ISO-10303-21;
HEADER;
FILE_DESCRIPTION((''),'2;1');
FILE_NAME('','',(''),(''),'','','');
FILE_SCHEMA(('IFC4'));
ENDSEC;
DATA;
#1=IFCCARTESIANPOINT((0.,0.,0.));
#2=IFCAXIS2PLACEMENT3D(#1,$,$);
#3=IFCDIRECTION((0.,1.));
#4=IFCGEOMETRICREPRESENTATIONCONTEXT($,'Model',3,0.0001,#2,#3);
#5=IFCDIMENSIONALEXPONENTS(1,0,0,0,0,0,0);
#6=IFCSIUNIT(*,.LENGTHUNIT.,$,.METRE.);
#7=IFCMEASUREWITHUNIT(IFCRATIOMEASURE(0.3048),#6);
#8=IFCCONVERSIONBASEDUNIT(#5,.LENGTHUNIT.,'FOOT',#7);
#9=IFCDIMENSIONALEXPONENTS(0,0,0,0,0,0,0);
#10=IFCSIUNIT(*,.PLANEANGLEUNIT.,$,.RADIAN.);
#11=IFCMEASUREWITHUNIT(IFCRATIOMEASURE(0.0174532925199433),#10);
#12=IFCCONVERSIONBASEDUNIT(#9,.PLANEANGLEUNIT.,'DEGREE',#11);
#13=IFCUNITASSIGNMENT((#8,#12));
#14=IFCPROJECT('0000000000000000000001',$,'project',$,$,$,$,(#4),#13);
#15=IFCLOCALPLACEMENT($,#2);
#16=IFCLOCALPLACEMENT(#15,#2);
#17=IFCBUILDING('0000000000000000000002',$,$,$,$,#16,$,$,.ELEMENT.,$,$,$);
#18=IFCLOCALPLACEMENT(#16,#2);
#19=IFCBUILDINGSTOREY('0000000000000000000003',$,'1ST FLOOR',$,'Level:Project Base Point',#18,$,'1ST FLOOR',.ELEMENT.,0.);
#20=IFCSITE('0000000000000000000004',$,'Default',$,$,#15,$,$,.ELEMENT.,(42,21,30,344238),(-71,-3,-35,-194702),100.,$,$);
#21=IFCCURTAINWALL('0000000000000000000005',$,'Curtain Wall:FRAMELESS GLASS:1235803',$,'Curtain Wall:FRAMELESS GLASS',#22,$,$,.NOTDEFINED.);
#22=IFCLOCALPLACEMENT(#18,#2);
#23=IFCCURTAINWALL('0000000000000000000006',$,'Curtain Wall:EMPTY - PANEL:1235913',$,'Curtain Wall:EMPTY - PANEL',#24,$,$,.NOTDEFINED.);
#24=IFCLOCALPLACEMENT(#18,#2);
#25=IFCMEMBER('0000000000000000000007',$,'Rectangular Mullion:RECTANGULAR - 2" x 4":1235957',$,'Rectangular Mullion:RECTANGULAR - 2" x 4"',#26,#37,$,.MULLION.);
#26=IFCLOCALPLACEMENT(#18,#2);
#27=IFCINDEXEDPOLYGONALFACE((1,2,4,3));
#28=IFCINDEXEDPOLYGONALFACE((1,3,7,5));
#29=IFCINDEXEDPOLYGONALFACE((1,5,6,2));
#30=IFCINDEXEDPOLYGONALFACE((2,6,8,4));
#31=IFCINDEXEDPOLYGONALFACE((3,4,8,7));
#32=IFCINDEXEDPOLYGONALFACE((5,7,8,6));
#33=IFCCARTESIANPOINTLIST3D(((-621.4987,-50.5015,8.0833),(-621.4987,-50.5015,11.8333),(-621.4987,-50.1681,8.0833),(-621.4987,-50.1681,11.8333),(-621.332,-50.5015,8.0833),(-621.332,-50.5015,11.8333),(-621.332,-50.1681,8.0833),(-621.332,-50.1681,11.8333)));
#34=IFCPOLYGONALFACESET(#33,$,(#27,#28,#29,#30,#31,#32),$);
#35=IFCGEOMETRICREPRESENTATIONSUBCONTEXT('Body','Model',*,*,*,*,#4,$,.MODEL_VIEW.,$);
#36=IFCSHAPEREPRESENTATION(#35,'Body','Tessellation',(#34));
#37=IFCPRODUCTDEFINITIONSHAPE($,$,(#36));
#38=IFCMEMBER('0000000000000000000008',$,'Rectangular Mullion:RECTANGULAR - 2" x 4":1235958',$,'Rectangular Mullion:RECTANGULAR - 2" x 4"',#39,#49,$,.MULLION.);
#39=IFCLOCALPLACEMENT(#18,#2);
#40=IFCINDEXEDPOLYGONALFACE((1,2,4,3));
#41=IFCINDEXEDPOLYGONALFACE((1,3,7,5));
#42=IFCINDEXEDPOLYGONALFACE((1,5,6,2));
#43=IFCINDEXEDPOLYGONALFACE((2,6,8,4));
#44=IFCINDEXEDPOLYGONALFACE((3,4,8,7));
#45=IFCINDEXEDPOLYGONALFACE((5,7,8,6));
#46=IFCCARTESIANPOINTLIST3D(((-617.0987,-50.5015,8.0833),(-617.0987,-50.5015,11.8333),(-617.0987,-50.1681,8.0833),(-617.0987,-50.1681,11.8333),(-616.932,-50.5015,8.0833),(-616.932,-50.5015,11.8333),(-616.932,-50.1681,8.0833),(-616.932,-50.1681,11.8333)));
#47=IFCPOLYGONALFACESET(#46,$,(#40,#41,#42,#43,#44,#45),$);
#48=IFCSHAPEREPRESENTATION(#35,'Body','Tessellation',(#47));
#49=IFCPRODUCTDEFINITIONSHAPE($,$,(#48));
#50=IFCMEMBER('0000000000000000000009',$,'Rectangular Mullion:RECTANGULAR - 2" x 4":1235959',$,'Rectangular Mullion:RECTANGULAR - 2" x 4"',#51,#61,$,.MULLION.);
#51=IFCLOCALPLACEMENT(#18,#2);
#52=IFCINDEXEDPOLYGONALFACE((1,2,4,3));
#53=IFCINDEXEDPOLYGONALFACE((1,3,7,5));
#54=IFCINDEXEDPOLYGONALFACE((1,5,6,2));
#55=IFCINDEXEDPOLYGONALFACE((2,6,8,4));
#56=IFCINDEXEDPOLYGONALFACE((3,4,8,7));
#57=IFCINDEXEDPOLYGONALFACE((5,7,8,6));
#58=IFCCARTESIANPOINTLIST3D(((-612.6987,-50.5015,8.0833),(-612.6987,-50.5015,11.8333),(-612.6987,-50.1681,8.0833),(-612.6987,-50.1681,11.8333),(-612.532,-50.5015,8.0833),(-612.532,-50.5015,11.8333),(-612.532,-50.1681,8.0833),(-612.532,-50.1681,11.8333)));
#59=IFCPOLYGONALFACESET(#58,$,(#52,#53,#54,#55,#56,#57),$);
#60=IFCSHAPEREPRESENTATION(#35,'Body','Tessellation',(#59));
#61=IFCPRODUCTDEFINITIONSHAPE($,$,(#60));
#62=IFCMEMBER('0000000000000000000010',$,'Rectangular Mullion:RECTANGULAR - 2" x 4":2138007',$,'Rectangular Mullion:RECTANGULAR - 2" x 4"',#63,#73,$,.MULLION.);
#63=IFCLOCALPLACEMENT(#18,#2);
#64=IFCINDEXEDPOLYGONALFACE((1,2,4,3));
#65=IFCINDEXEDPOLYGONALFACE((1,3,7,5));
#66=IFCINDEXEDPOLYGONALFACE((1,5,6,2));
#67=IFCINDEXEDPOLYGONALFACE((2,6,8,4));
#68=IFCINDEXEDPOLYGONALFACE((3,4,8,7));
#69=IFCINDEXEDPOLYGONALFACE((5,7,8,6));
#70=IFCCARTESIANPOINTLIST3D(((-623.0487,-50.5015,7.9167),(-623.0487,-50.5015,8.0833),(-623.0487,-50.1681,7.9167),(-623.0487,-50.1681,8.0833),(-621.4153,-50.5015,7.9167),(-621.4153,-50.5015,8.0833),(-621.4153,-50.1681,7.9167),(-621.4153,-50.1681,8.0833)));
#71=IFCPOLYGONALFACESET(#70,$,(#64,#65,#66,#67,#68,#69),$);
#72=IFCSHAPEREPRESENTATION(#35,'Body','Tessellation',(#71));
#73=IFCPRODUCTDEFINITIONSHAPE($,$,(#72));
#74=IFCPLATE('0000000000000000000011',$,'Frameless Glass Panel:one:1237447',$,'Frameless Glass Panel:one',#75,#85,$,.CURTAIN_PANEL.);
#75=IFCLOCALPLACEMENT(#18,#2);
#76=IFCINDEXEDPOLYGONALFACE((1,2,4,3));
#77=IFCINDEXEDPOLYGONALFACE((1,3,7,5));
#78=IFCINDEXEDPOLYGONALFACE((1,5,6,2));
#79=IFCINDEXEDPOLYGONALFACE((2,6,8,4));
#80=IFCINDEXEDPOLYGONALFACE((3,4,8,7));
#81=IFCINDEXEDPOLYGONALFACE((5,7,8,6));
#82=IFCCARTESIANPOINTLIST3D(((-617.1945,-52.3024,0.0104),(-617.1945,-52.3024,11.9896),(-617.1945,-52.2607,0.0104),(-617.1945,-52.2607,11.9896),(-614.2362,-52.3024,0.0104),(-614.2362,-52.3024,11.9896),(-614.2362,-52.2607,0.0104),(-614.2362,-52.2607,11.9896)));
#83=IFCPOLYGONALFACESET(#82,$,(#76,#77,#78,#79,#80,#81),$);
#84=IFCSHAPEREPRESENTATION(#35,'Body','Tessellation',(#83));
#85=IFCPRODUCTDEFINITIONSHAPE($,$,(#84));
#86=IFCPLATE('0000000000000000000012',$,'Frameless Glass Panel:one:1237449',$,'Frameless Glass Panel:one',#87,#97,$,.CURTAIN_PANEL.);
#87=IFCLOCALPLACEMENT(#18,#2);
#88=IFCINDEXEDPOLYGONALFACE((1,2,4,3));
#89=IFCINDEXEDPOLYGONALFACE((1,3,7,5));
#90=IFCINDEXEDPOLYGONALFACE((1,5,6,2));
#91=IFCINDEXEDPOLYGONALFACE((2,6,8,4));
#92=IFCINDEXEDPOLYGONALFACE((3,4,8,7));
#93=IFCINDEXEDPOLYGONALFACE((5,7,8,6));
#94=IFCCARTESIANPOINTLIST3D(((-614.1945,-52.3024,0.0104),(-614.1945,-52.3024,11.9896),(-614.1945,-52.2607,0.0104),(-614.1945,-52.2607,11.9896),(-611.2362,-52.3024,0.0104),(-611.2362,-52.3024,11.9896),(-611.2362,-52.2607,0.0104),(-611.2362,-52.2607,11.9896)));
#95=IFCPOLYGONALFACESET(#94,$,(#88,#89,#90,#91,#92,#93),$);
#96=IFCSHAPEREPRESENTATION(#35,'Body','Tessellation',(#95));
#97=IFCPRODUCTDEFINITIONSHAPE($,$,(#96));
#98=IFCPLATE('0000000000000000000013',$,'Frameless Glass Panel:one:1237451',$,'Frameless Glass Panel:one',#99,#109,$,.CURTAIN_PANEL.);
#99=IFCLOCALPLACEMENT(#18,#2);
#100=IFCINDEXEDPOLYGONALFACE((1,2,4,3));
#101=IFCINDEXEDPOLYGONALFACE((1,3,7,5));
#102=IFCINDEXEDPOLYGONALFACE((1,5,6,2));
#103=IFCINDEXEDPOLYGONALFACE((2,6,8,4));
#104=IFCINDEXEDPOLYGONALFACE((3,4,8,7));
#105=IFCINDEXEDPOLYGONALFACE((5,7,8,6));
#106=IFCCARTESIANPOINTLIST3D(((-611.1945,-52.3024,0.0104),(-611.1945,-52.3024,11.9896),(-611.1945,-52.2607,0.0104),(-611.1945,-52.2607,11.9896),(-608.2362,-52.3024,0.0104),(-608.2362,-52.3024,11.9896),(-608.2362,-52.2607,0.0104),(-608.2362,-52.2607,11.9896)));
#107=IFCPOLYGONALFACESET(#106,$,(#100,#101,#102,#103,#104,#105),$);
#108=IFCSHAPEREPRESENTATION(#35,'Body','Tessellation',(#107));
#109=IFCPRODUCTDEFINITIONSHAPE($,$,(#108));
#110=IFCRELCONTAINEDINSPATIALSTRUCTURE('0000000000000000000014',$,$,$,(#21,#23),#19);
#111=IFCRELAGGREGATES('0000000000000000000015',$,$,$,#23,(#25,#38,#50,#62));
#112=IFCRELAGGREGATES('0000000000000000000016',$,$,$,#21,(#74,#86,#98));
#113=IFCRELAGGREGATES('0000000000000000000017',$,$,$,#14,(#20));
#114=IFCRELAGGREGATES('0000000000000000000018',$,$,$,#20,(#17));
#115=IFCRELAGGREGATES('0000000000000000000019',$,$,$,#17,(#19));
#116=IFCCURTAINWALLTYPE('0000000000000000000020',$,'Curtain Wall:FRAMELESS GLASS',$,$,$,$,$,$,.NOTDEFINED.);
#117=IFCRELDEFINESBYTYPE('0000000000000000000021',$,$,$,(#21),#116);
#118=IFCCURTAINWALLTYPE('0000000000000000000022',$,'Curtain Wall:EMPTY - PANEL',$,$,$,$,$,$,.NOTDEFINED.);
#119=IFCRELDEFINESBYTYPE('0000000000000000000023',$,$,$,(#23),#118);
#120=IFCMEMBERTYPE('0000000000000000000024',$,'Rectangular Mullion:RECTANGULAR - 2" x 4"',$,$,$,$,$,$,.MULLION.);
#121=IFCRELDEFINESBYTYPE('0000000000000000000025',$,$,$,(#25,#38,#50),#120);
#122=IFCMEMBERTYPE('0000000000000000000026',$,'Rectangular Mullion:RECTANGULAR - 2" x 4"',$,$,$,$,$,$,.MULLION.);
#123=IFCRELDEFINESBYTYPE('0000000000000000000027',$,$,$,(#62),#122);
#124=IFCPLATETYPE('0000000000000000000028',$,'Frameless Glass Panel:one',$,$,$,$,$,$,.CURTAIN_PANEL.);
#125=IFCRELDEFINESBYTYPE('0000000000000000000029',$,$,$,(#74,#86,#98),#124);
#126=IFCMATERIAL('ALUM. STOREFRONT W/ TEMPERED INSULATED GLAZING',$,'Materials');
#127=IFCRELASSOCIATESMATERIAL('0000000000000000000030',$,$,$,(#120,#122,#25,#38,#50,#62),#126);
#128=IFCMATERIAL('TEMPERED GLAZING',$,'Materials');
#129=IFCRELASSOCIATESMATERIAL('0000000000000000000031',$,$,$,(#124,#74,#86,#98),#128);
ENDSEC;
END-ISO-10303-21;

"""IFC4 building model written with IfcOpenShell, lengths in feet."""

from ifc_helpers import new_model, entity, si_unit, converted_unit, direction, frame, origin, origin_2d_with_axis, place, context, subcontext, project, spatial, rectangle, extrude, source, transform, mapped, material, material_profile, profile_set, profile_usage, type_object, type_shapes, element, aggregate, save


model = new_model("IFC4")

# Units and contexts
model_context = context("Model", 3, precision=0.0001, world=origin(), true_north=direction((0.0, 1.0)))
body_context = subcontext(model_context, "Body", "Model", "MODEL_VIEW")
ifc_project = project(units=[converted_unit("LENGTHUNIT", "FOOT", entity("IfcRatioMeasure", 0.3048), si_unit("LENGTHUNIT", "METRE"), dimensions=[1, 0, 0, 0, 0, 0, 0]), converted_unit("PLANEANGLEUNIT", "DEGREE", entity("IfcRatioMeasure", 0.0174532925199433), si_unit("PLANEANGLEUNIT", "RADIAN"), dimensions=[0, 0, 0, 0, 0, 0, 0])], contexts=[model_context])

# Site, building, storey
site_placement = place(None, origin())
site = spatial("IfcSite", under=ifc_project, at=site_placement, Name="Default", CompositionType="ELEMENT", RefLatitude=(42, 21, 30, 344238), RefLongitude=(-71, -3, -35, -194702), RefElevation=100.0)
building_placement = place(site_placement, origin())
building = spatial("IfcBuilding", under=site, at=building_placement, CompositionType="ELEMENT")
storey_placement = place(building_placement, origin())
storey = spatial("IfcBuildingStorey", under=building, at=storey_placement, Name="1ST FLOOR", ObjectType="Level:Project Base Point", LongName="1ST FLOOR", CompositionType="ELEMENT", Elevation=0.0)

# Curtain walls, members
curtain_wall_type_1 = type_object("IfcCurtainWallType", Name="Curtain Wall:FRAMELESS GLASS", PredefinedType="NOTDEFINED")
curtain_wall_1_placement = place(storey_placement, origin())
curtain_wall_1 = element("IfcCurtainWall", 1, at=curtain_wall_1_placement, inside=storey, type_object=curtain_wall_type_1, Name="Curtain Wall:FRAMELESS GLASS:1235803", ObjectType="Curtain Wall:FRAMELESS GLASS", PredefinedType="NOTDEFINED")
curtain_wall_type_2 = type_object("IfcCurtainWallType", Name="Curtain Wall:EMPTY - PANEL", PredefinedType="NOTDEFINED")
curtain_wall_2_placement = place(storey_placement, origin())
curtain_wall_2 = element("IfcCurtainWall", 2, at=curtain_wall_2_placement, inside=storey, type_object=curtain_wall_type_2, Name="Curtain Wall:EMPTY - PANEL:1235913", ObjectType="Curtain Wall:EMPTY - PANEL", PredefinedType="NOTDEFINED")
ifc_material_1 = material(Name="ALUM. STOREFRONT W/ TEMPERED INSULATED GLAZING", Category="Materials")
ifc_material_profile_1 = material_profile(ifc_material_1, rectangle(XDim=0.3333, YDim=0.1667, at=origin_2d_with_axis()), Name="RECTANGULAR - 2\" x 4\"")
ifc_profile_set_1 = profile_set([ifc_material_profile_1], Name="RECTANGULAR - 2\" x 4\"")
ifc_profile_usage_1 = profile_usage(ifc_profile_set_1)
member_type_1 = type_object("IfcMemberType", Name="Rectangular Mullion:RECTANGULAR - 2\" x 4\"", PredefinedType="MULLION", material=ifc_profile_set_1)
shared_shape_1 = source(origin(), body_context, "Body", "SweptSolid", [
    extrude(rectangle(XDim=0.3333, YDim=0.1667, at=origin_2d_with_axis()), frame((0.0, 0.0, -3.75), z_axis=(0.0, 0.0, 1.0), x_axis=(0.0, -1.0, 0.0)), (0.0, 0.0, 1.0), 3.75),
])
type_shapes(member_type_1, [shared_shape_1])
member_1_placement = place(storey_placement, frame((-621.4153, -50.3348, 8.0833), z_axis=(0.0, 0.0, -1.0), x_axis=(1.0, 0.0, 0.0)))
member_1 = element("IfcMember", 3, at=member_1_placement, type_object=member_type_1, material=ifc_profile_usage_1, Name="Rectangular Mullion:RECTANGULAR - 2\" x 4\":1235957", ObjectType="Rectangular Mullion:RECTANGULAR - 2\" x 4\"", PredefinedType="MULLION", context=body_context, shape_type="MappedRepresentation", body=[
    mapped(shared_shape_1, transform((0.0, 0.0, 0.0), scale=1.0)),
])
ifc_profile_usage_2 = profile_usage(ifc_profile_set_1)
member_2_placement = place(storey_placement, frame((-617.0153, -50.3348, 8.0833), z_axis=(0.0, 0.0, -1.0), x_axis=(1.0, 0.0, 0.0)))
member_2 = element("IfcMember", 4, at=member_2_placement, type_object=member_type_1, material=ifc_profile_usage_2, Name="Rectangular Mullion:RECTANGULAR - 2\" x 4\":1235958", ObjectType="Rectangular Mullion:RECTANGULAR - 2\" x 4\"", PredefinedType="MULLION", context=body_context, shape_type="MappedRepresentation", body=[
    mapped(shared_shape_1, transform((0.0, 0.0, 0.0), scale=1.0)),
])
ifc_profile_usage_3 = profile_usage(ifc_profile_set_1)
member_3_placement = place(storey_placement, frame((-612.6153, -50.3348, 8.0833), z_axis=(0.0, 0.0, -1.0), x_axis=(1.0, 0.0, 0.0)))
member_3 = element("IfcMember", 5, at=member_3_placement, type_object=member_type_1, material=ifc_profile_usage_3, Name="Rectangular Mullion:RECTANGULAR - 2\" x 4\":1235959", ObjectType="Rectangular Mullion:RECTANGULAR - 2\" x 4\"", PredefinedType="MULLION", context=body_context, shape_type="MappedRepresentation", body=[
    mapped(shared_shape_1, transform((0.0, 0.0, 0.0), scale=1.0)),
])
ifc_profile_usage_4 = profile_usage(ifc_profile_set_1)
member_type_2 = type_object("IfcMemberType", Name="Rectangular Mullion:RECTANGULAR - 2\" x 4\"", PredefinedType="MULLION", material=ifc_profile_set_1)
shared_shape_2 = source(origin(), body_context, "Body", "SweptSolid", [
    extrude(rectangle(XDim=0.3333, YDim=0.1667, at=origin_2d_with_axis()), frame((0.0, 0.0, -1.6333), z_axis=(0.0, 0.0, 1.0), x_axis=(0.0, -1.0, 0.0)), (0.0, 0.0, 1.0), 1.6333),
])
type_shapes(member_type_2, [shared_shape_2])
member_4_placement = place(storey_placement, frame((-621.4153, -50.3348, 8.0), z_axis=(1.0, 0.0, 0.0), x_axis=(0.0, 0.0, 1.0)))
member_4 = element("IfcMember", 6, at=member_4_placement, type_object=member_type_2, material=ifc_profile_usage_4, Name="Rectangular Mullion:RECTANGULAR - 2\" x 4\":2138007", ObjectType="Rectangular Mullion:RECTANGULAR - 2\" x 4\"", PredefinedType="MULLION", context=body_context, shape_type="MappedRepresentation", body=[
    mapped(shared_shape_2, transform((0.0, 0.0, 0.0), scale=1.0)),
])
aggregate(curtain_wall_2, [member_1, member_2, member_3, member_4])

# Plates
ifc_material_2 = material(Name="TEMPERED GLAZING", Category="Materials")
plate_type = type_object("IfcPlateType", Name="Frameless Glass Panel:one", PredefinedType="CURTAIN_PANEL", material=ifc_material_2)
shared_shape_3 = source(origin(), body_context, "Body", "SweptSolid", [
    extrude(rectangle(XDim=0.0417, YDim=2.9583, at=origin_2d_with_axis()), frame((0.0, 0.0, 0.0), z_axis=(0.0, 0.0, 1.0), x_axis=(0.0, 1.0, 0.0)), (0.0, 0.0, 1.0), 11.9792),
])
type_shapes(plate_type, [shared_shape_3])
plate_1_placement = place(curtain_wall_1_placement, frame((-615.7153, -52.2815, 0.0104)))
plate_1 = element("IfcPlate", 7, at=plate_1_placement, type_object=plate_type, material=ifc_material_2, Name="Frameless Glass Panel:one:1237447", ObjectType="Frameless Glass Panel:one", PredefinedType="CURTAIN_PANEL", context=body_context, shape_type="MappedRepresentation", body=[
    mapped(shared_shape_3, transform((0.0, 0.0, 0.0), scale=1.0)),
])
plate_2_placement = place(curtain_wall_1_placement, frame((-612.7153, -52.2815, 0.0104)))
plate_2 = element("IfcPlate", 8, at=plate_2_placement, type_object=plate_type, material=ifc_material_2, Name="Frameless Glass Panel:one:1237449", ObjectType="Frameless Glass Panel:one", PredefinedType="CURTAIN_PANEL", context=body_context, shape_type="MappedRepresentation", body=[
    mapped(shared_shape_3, transform((0.0, 0.0, 0.0), scale=1.0)),
])
plate_3_placement = place(curtain_wall_1_placement, frame((-609.7153, -52.2815, 0.0104)))
plate_3 = element("IfcPlate", 9, at=plate_3_placement, type_object=plate_type, material=ifc_material_2, Name="Frameless Glass Panel:one:1237451", ObjectType="Frameless Glass Panel:one", PredefinedType="CURTAIN_PANEL", context=body_context, shape_type="MappedRepresentation", body=[
    mapped(shared_shape_3, transform((0.0, 0.0, 0.0), scale=1.0)),
])
aggregate(curtain_wall_1, [plate_1, plate_2, plate_3])

save(model, "model.ifc")
